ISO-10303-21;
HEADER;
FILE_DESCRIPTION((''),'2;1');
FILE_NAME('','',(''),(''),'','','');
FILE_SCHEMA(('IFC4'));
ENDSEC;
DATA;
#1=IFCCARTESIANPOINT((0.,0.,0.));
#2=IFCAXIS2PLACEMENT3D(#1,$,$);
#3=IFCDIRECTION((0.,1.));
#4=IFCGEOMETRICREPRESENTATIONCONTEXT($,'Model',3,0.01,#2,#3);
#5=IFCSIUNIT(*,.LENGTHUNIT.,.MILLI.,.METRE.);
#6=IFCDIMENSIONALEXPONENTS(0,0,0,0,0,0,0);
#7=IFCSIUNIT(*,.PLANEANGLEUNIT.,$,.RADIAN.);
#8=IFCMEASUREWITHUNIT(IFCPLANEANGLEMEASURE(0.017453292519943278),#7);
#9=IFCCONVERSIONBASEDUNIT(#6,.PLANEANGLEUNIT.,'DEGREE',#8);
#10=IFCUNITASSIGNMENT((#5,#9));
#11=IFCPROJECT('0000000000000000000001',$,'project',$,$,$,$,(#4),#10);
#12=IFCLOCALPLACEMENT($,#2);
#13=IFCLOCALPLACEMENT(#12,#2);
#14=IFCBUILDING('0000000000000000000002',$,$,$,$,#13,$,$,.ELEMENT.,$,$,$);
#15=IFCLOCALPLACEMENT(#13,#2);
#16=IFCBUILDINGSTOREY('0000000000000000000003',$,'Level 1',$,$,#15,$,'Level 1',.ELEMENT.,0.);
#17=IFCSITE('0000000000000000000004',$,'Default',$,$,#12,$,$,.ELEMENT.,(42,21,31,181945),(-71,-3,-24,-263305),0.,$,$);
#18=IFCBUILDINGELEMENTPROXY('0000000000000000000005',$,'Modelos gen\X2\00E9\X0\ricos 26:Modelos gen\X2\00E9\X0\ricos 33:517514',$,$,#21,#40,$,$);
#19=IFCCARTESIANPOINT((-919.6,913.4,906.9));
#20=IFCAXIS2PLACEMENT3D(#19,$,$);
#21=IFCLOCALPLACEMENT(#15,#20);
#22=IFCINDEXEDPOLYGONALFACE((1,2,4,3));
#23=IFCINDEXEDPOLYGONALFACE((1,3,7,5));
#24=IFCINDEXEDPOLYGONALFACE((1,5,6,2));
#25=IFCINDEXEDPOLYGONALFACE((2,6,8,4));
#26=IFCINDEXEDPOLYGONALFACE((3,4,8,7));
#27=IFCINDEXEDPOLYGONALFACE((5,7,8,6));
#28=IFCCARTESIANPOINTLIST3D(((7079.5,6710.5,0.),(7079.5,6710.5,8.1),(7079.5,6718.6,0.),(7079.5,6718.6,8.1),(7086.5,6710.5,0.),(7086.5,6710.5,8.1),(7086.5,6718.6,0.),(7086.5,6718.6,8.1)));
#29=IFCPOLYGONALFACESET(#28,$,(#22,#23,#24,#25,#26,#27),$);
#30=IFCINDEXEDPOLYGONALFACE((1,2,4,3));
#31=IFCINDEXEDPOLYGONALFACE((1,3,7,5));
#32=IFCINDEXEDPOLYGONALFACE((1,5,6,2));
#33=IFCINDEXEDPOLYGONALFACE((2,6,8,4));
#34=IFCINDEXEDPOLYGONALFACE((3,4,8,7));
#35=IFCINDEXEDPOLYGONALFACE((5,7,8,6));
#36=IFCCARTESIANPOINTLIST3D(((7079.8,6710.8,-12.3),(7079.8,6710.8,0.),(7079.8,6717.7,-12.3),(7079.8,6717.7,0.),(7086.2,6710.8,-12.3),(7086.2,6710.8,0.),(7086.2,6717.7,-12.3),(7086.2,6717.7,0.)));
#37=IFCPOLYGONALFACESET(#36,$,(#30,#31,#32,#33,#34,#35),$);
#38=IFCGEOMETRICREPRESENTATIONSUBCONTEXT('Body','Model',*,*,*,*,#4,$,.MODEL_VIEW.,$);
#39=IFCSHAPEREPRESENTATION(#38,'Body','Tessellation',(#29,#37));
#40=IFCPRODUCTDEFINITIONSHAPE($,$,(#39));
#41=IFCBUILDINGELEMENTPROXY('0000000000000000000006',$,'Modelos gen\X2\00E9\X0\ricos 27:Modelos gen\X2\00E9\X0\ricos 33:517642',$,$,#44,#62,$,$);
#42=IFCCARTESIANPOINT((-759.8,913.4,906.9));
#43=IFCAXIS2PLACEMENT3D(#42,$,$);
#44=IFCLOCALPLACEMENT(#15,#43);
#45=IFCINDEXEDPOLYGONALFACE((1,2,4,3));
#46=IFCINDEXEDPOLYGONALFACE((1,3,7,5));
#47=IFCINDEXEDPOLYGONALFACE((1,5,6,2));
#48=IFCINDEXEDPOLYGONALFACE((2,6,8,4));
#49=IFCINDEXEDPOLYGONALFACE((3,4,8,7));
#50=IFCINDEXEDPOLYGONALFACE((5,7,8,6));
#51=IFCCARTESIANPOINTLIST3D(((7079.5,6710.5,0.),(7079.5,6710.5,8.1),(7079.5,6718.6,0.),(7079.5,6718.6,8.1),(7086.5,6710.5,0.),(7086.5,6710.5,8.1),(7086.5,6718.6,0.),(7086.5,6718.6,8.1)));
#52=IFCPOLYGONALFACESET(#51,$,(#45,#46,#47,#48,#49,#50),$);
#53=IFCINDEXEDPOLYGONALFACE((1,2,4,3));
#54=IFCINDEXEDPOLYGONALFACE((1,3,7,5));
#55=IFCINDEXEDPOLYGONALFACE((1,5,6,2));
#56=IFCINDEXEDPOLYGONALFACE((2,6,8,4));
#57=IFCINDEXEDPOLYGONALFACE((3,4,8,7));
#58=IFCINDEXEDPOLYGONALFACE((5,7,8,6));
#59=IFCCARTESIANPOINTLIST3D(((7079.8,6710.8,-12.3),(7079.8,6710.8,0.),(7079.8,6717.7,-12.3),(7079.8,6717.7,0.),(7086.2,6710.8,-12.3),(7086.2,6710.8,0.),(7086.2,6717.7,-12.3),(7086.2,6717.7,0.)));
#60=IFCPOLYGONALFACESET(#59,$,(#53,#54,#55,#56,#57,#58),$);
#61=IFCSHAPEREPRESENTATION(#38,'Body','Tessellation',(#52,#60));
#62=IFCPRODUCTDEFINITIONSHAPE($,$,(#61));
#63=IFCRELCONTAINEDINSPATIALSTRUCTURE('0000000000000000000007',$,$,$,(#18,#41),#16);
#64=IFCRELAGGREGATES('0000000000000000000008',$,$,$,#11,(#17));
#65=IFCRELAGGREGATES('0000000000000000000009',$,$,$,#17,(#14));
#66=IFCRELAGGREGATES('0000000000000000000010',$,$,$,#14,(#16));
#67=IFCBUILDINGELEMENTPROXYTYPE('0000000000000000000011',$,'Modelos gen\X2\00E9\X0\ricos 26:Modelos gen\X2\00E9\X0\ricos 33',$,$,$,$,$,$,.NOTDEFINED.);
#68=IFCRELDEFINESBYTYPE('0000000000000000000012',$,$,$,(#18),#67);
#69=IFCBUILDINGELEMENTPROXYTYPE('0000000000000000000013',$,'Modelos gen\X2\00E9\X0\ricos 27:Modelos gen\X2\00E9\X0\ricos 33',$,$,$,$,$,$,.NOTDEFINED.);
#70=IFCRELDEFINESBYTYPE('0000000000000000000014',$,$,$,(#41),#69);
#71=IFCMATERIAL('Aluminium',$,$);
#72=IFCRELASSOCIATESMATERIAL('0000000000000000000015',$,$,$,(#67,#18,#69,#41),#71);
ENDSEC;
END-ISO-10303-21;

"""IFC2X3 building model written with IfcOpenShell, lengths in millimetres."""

from ifc_helpers import new_model, entity, si_unit, converted_unit, direction, frame, frame_2d, origin, place, context, subcontext, project, spatial, rectangle, extrude, source, transform, mapped, material, type_object, type_shapes, element, save


model = new_model("IFC2X3")

# Units and contexts
model_context = context("Model", 3, precision=0.01, world=origin(), true_north=direction((0.0, 1.0)))
body_context = subcontext(model_context, "Body", "Model", "MODEL_VIEW")
ifc_project = project(units=[si_unit("LENGTHUNIT", "METRE", prefix="MILLI"), converted_unit("PLANEANGLEUNIT", "DEGREE", entity("IfcPlaneAngleMeasure", 0.017453292519943278), si_unit("PLANEANGLEUNIT", "RADIAN"), dimensions=[0, 0, 0, 0, 0, 0, 0])], contexts=[model_context])

# Site, building, storey
site_placement = place(None, origin())
site = spatial("IfcSite", under=ifc_project, at=site_placement, Name="Default", CompositionType="ELEMENT", RefLatitude=(42, 21, 31, 181945), RefLongitude=(-71, -3, -24, -263305), RefElevation=0.0)
building_placement = place(site_placement, origin())
building = spatial("IfcBuilding", under=site, at=building_placement, CompositionType="ELEMENT")
storey_placement = place(building_placement, origin())
storey = spatial("IfcBuildingStorey", under=building, at=storey_placement, Name="Level 1", LongName="Level 1", CompositionType="ELEMENT", Elevation=0.0)

# Building element proxies
ifc_material_1 = material(Name="Aluminium")
building_element_proxy_type_1 = type_object("IfcBuildingElementProxyType", Name="Modelos genéricos 26:Modelos genéricos 33", PredefinedType="NOTDEFINED", material=ifc_material_1)
shared_shape_1 = source(origin(), body_context, "Body", "SweptSolid", [
    extrude(rectangle(XDim=8.2, YDim=7.0, at=frame_2d((0.0, 0.0), x_axis=(1.0, 0.0))), frame((7083.0, 6714.5, 0.0), z_axis=(0.0, 0.0, 1.0), x_axis=(0.0, 1.0, 0.0)), (0.0, 0.0, 1.0), 8.1),
    extrude(rectangle(XDim=6.9, YDim=6.4, at=frame_2d((0.0, 0.0), x_axis=(1.0, 0.0))), frame((7083.0, 6714.2, -12.3), z_axis=(0.0, 0.0, 1.0), x_axis=(0.0, 1.0, 0.0)), (0.0, 0.0, 1.0), 12.3),
])
type_shapes(building_element_proxy_type_1, [shared_shape_1])
proxy_1_placement = place(storey_placement, frame((-919.6, 913.4, 906.9)))
element("IfcBuildingElementProxy", 1, at=proxy_1_placement, inside=storey, type_object=building_element_proxy_type_1, material=ifc_material_1, Name="Modelos genéricos 26:Modelos genéricos 33:517514", context=body_context, shape_type="MappedRepresentation", body=[
    mapped(shared_shape_1, transform((0.0, 0.0, 0.0), scale=1.0)),
])
building_element_proxy_type_2 = type_object("IfcBuildingElementProxyType", Name="Modelos genéricos 27:Modelos genéricos 33", PredefinedType="NOTDEFINED", material=ifc_material_1)
shared_shape_2 = source(origin(), body_context, "Body", "SweptSolid", [
    extrude(rectangle(XDim=8.2, YDim=7.0, at=frame_2d((0.0, 0.0), x_axis=(1.0, 0.0))), frame((7083.0, 6714.5, 0.0), z_axis=(0.0, 0.0, 1.0), x_axis=(0.0, 1.0, 0.0)), (0.0, 0.0, 1.0), 8.1),
    extrude(rectangle(XDim=6.9, YDim=6.4, at=frame_2d((0.0, 0.0), x_axis=(1.0, 0.0))), frame((7083.0, 6714.2, -12.3), z_axis=(0.0, 0.0, 1.0), x_axis=(0.0, 1.0, 0.0)), (0.0, 0.0, 1.0), 12.3),
])
type_shapes(building_element_proxy_type_2, [shared_shape_2])
proxy_2_placement = place(storey_placement, frame((-759.8, 913.4, 906.9)))
element("IfcBuildingElementProxy", 2, at=proxy_2_placement, inside=storey, type_object=building_element_proxy_type_2, material=ifc_material_1, Name="Modelos genéricos 27:Modelos genéricos 33:517642", context=body_context, shape_type="MappedRepresentation", body=[
    mapped(shared_shape_2, transform((0.0, 0.0, 0.0), scale=1.0)),
])

save(model, "model.ifc")
